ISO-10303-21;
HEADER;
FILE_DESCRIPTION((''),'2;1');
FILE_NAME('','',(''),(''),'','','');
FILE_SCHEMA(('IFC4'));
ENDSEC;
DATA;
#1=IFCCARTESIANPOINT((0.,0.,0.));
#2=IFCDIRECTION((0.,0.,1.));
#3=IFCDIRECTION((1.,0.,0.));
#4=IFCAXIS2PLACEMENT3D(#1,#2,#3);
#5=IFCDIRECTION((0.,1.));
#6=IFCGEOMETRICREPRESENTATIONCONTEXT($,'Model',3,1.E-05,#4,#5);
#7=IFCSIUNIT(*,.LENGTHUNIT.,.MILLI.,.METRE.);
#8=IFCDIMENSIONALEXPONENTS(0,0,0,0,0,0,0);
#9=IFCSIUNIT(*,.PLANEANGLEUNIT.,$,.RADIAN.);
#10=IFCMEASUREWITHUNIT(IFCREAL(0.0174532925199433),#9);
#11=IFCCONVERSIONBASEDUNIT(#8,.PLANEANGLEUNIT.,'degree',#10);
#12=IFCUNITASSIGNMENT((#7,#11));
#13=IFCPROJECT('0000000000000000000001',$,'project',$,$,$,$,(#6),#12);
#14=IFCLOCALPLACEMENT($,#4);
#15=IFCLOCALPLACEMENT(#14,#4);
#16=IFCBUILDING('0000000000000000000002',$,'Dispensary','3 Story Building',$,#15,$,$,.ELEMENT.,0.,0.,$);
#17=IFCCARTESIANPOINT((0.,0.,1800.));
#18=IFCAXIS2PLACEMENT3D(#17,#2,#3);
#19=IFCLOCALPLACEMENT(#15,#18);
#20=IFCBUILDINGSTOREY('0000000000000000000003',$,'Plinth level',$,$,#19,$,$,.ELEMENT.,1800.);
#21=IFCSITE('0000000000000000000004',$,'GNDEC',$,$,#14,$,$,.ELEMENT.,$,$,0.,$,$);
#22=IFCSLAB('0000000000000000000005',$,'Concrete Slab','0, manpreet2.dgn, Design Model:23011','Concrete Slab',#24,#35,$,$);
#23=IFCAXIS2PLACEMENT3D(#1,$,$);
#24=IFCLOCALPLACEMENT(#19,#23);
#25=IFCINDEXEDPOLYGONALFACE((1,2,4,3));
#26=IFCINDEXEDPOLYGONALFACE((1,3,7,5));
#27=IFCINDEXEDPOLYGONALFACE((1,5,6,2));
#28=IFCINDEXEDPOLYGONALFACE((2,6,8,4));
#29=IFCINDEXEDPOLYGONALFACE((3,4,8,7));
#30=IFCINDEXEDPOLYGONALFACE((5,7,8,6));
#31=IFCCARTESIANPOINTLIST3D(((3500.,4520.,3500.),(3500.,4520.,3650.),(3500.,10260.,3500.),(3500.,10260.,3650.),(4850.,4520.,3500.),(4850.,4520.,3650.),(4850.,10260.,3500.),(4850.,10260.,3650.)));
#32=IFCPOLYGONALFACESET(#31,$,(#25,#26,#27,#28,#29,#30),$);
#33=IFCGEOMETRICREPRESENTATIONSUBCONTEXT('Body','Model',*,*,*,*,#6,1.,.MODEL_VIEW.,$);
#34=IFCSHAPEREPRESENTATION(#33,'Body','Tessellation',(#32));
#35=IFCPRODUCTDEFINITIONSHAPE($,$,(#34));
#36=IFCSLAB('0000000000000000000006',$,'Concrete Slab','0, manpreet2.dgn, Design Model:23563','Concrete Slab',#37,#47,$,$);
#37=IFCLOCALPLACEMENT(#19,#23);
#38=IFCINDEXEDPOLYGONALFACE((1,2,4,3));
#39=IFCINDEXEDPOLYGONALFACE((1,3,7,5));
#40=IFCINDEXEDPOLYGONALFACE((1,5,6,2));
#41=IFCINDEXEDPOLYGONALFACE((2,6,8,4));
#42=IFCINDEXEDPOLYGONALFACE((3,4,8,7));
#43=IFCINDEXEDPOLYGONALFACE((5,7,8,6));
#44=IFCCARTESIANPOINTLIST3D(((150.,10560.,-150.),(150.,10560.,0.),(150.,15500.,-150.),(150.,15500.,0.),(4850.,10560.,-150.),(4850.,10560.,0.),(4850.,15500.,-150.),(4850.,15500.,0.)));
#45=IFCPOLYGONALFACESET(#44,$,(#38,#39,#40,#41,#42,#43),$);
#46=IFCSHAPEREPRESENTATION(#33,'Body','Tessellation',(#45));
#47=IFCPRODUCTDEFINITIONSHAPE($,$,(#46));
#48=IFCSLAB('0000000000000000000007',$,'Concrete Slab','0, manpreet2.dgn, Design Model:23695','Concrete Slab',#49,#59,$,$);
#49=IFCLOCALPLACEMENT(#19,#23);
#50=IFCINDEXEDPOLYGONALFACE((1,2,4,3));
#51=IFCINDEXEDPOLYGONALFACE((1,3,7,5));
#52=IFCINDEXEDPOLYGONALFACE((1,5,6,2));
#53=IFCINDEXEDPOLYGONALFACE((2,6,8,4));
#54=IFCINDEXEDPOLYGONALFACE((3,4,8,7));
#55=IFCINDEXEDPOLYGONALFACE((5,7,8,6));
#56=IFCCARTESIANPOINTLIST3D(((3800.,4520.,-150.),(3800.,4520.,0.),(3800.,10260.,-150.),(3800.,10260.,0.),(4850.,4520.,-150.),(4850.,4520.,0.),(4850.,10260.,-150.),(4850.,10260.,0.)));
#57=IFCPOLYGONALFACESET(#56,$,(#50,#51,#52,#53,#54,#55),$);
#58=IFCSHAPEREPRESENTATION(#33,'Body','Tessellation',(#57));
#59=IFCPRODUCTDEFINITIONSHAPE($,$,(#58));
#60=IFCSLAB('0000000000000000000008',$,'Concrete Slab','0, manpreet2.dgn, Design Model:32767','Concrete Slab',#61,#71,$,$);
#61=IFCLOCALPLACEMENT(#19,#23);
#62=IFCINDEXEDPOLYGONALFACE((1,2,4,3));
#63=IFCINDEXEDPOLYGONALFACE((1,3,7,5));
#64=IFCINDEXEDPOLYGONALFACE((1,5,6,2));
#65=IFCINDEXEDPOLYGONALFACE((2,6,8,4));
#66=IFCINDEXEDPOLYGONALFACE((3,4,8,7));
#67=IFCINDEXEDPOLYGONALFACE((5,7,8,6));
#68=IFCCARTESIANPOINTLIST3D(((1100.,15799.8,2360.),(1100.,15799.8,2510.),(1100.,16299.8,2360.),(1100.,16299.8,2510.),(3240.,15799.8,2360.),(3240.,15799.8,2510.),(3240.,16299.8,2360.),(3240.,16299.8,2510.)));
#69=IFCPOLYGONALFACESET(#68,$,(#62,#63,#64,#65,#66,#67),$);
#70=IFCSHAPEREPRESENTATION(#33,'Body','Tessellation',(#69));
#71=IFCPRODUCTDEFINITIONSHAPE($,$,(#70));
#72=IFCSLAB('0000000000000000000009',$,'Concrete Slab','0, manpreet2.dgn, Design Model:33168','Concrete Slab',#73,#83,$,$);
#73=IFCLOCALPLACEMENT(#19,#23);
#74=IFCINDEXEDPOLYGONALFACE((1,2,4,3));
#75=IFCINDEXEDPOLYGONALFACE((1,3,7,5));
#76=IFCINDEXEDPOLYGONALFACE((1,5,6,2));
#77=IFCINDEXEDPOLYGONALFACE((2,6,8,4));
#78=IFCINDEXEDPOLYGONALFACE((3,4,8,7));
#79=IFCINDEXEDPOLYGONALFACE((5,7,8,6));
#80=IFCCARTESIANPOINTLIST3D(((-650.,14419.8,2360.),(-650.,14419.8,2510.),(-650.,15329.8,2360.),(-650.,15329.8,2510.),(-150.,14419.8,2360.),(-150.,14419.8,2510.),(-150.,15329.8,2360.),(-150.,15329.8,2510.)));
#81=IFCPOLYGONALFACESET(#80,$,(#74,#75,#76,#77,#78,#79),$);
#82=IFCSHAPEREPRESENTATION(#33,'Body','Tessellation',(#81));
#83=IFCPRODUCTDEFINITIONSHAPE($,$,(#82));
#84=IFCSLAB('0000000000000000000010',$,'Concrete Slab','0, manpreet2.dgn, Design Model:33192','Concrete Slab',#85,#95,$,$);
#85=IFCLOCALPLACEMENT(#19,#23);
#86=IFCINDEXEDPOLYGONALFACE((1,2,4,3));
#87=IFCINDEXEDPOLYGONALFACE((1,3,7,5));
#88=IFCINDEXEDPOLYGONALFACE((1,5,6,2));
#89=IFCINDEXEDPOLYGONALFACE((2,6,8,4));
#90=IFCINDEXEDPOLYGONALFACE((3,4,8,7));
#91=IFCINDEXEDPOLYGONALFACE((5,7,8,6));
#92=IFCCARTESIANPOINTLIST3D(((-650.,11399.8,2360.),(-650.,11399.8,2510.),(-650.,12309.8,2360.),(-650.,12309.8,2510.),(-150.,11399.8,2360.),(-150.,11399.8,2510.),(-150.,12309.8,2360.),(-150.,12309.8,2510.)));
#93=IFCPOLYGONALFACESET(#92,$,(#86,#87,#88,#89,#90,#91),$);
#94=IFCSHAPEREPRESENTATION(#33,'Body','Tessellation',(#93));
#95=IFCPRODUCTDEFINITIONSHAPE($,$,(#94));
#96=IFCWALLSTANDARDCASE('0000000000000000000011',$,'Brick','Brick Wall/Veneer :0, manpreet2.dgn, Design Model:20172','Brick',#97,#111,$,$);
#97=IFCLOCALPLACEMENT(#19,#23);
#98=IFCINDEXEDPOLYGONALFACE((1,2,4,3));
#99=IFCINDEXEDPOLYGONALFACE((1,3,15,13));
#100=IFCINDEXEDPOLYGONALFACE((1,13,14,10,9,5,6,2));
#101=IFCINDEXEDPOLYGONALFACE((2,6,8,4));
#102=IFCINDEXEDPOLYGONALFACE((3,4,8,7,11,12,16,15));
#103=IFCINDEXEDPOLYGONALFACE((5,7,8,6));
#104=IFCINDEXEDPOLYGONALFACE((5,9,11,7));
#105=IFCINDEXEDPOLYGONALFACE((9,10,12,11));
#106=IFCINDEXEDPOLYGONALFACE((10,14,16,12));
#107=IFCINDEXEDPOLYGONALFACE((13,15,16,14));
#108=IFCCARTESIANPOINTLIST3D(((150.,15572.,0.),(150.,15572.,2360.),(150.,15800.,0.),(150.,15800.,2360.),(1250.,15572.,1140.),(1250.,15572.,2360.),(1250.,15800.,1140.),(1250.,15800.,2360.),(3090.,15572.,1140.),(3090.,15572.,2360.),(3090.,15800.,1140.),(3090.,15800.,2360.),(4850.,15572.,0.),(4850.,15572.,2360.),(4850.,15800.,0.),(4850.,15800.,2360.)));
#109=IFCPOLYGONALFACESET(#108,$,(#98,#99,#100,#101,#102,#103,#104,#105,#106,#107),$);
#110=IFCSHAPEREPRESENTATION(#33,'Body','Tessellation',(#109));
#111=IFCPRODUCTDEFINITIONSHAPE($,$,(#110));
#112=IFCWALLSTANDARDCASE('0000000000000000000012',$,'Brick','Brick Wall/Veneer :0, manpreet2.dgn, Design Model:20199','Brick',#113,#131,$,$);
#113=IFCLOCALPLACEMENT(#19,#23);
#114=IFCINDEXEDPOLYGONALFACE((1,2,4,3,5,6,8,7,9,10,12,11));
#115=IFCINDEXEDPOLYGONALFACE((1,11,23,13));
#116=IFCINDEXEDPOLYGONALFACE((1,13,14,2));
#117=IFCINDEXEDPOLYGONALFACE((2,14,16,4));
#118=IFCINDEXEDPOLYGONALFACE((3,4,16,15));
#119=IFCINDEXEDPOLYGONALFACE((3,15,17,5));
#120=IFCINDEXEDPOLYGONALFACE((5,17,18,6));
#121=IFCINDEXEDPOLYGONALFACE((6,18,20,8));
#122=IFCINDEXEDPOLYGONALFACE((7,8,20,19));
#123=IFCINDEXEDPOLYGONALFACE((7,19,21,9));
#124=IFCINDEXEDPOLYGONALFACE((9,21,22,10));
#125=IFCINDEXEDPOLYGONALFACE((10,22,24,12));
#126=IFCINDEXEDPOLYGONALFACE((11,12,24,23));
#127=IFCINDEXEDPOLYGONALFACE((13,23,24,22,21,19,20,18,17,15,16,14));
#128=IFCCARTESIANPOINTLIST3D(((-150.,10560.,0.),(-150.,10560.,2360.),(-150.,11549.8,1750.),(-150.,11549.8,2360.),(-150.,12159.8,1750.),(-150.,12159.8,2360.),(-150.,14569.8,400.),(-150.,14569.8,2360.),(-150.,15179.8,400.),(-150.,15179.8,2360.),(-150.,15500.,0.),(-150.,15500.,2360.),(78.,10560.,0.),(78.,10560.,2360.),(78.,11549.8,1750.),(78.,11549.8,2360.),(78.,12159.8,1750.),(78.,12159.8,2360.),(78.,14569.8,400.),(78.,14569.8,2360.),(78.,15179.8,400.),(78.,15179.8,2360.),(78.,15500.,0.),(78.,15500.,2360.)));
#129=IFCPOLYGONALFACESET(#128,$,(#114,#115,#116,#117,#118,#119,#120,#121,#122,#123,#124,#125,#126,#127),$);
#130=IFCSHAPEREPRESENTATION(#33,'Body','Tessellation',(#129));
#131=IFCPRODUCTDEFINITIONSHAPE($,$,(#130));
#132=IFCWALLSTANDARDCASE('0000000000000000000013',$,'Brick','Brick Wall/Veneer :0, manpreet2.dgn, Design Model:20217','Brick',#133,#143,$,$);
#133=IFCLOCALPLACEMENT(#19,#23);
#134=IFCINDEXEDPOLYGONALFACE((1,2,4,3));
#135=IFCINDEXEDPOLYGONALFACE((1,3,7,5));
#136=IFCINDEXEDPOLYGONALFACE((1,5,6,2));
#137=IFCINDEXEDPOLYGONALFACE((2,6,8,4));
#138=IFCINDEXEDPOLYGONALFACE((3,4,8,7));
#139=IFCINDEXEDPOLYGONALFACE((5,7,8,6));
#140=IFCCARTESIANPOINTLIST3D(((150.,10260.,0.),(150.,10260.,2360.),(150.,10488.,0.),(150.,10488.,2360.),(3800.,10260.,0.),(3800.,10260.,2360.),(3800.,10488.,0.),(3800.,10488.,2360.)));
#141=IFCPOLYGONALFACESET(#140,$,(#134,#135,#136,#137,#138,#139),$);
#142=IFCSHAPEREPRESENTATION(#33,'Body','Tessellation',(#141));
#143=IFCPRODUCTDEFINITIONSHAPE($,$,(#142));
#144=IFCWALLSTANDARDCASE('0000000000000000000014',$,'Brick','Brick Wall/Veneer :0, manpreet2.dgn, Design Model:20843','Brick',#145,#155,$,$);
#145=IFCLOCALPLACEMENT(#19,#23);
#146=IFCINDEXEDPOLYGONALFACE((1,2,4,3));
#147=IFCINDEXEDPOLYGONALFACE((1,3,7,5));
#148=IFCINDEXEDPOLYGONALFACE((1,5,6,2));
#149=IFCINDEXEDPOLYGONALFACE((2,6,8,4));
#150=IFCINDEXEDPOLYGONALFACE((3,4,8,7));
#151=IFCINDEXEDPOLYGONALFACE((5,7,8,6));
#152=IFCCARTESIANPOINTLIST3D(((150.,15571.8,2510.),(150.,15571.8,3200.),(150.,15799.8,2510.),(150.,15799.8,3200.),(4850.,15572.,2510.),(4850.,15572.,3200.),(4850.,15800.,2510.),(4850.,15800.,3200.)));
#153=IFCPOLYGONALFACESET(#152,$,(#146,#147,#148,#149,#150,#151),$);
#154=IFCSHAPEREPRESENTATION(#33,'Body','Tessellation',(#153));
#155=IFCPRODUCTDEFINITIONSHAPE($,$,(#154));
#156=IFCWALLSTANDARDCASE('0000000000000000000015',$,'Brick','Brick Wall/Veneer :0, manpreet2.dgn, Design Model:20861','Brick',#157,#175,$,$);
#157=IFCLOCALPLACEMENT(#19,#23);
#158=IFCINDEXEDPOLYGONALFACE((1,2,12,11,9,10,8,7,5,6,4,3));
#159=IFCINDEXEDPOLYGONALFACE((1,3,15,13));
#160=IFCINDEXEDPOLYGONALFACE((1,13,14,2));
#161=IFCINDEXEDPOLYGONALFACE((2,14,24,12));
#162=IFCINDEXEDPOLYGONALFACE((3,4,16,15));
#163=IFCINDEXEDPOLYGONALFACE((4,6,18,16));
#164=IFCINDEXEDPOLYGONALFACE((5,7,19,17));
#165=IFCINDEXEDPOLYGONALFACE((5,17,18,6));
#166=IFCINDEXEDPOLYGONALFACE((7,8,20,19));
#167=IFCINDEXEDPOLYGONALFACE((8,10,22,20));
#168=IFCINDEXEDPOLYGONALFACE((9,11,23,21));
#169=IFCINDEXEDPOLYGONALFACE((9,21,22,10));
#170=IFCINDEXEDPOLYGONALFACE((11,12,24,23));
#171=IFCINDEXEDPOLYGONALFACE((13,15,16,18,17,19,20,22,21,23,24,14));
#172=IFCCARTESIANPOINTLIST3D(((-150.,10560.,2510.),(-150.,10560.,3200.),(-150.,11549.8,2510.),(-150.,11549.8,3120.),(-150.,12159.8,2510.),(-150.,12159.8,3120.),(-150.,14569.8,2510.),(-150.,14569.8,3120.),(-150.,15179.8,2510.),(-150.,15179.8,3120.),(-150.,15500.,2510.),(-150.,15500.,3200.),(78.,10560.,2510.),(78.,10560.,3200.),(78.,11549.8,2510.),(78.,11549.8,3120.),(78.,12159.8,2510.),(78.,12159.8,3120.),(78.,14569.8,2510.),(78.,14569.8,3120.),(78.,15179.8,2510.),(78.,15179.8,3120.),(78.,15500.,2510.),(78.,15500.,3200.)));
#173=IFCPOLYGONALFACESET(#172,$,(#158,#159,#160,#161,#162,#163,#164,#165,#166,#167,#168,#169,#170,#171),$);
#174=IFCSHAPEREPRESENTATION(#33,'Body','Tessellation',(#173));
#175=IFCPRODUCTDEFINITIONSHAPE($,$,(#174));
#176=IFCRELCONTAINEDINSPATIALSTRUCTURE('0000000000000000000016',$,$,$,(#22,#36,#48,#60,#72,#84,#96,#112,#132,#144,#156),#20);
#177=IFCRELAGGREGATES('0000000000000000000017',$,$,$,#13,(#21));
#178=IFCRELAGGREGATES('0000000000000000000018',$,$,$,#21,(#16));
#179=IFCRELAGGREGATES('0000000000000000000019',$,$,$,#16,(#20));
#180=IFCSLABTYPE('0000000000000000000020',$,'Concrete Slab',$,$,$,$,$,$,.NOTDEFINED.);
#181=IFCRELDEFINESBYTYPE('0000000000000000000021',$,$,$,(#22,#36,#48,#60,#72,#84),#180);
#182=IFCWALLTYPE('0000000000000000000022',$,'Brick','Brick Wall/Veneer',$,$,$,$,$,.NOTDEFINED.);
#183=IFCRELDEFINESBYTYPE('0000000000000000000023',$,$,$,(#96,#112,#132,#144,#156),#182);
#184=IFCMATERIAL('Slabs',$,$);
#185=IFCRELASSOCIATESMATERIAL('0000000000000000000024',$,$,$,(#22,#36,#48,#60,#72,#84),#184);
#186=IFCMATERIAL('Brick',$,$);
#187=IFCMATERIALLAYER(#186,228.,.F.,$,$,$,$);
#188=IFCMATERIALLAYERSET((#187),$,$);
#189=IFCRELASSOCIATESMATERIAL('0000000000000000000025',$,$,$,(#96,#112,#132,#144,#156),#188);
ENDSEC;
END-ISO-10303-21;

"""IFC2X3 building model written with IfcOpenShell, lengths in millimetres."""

from ifc_helpers import new_model, entity, si_unit, converted_unit, direction, frame, frame_2d, origin_with_axes, place, context, subcontext, project, spatial, rectangle, extrude, material, layer, layer_set, layer_usage, type_object, element, save


model = new_model("IFC2X3")

# Units and contexts
model_context = context("Model", 3, precision=1e-05, world=origin_with_axes(), true_north=direction((0.0, 1.0)))
body_context = subcontext(model_context, "Body", "Model", "MODEL_VIEW", scale=1.0)
ifc_project = project(units=[si_unit("LENGTHUNIT", "METRE", prefix="MILLI"), converted_unit("PLANEANGLEUNIT", "degree", entity("IfcReal", 0.0174532925199433), si_unit("PLANEANGLEUNIT", "RADIAN"), dimensions=[0, 0, 0, 0, 0, 0, 0])], contexts=[model_context])

# Site, building, storey
site_placement = place(None, origin_with_axes())
site = spatial("IfcSite", under=ifc_project, at=site_placement, Name="GNDEC", CompositionType="ELEMENT", RefElevation=0.0)
building_placement = place(site_placement, origin_with_axes())
building = spatial("IfcBuilding", under=site, at=building_placement, Name="Dispensary", Description="3 Story Building", CompositionType="ELEMENT", ElevationOfRefHeight=0.0, ElevationOfTerrain=0.0)
storey_placement = place(building_placement, frame((0.0, 0.0, 1800.0), z_axis=(0.0, 0.0, 1.0), x_axis=(1.0, 0.0, 0.0)))
storey = spatial("IfcBuildingStorey", under=building, at=storey_placement, Name="Plinth level", CompositionType="ELEMENT", Elevation=1800.0)

# Slabs
ifc_material_1 = material(Name="Slabs")
slab_type = type_object("IfcSlabType", Name="Concrete Slab", PredefinedType="NOTDEFINED")
slab_1_placement = place(storey_placement, frame((3500.0, 10260.0, 3500.0), z_axis=(0.0, 0.0, 1.0), x_axis=(0.0, -1.0, 0.0)))
element("IfcSlab", 1, at=slab_1_placement, inside=storey, type_object=slab_type, material=ifc_material_1, Name="Concrete Slab", Description="0, manpreet2.dgn, Design Model:23011", ObjectType="Concrete Slab", context=body_context, shape_type="SweptSolid", body=[
    extrude(rectangle(XDim=5740.0, YDim=1350.0, at=frame_2d((2870.0, 675.0), x_axis=(1.0, 0.0))), origin_with_axes(), (0.0, 0.0, 1.0), 150.0),
])
slab_2_placement = place(storey_placement, frame((150.0, 15500.0, 0.0), z_axis=(0.0, 0.0, -1.0), x_axis=(1.0, 0.0, 0.0)))
element("IfcSlab", 2, at=slab_2_placement, inside=storey, type_object=slab_type, material=ifc_material_1, Name="Concrete Slab", Description="0, manpreet2.dgn, Design Model:23563", ObjectType="Concrete Slab", context=body_context, shape_type="SweptSolid", body=[
    extrude(rectangle(XDim=4700.0, YDim=4940.0, at=frame_2d((2350.0, 2470.0), x_axis=(1.0, 0.0))), origin_with_axes(), (0.0, 0.0, 1.0), 150.0),
])
slab_3_placement = place(storey_placement, frame((4850.0, 10260.0, 0.0), z_axis=(0.0, 0.0, -1.0), x_axis=(0.0, -1.0, 0.0)))
element("IfcSlab", 3, at=slab_3_placement, inside=storey, type_object=slab_type, material=ifc_material_1, Name="Concrete Slab", Description="0, manpreet2.dgn, Design Model:23695", ObjectType="Concrete Slab", context=body_context, shape_type="SweptSolid", body=[
    extrude(rectangle(XDim=5740.0, YDim=1050.0, at=frame_2d((2870.0, 525.0), x_axis=(1.0, 0.0))), origin_with_axes(), (0.0, 0.0, 1.0), 150.0),
])
slab_4_placement = place(storey_placement, frame((1250.0, 15799.8, 2510.0), z_axis=(0.0, 0.0, -1.0), x_axis=(-1.0, 0.0, 0.0)))
element("IfcSlab", 4, at=slab_4_placement, inside=storey, type_object=slab_type, material=ifc_material_1, Name="Concrete Slab", Description="0, manpreet2.dgn, Design Model:32767", ObjectType="Concrete Slab", context=body_context, shape_type="SweptSolid", body=[
    extrude(rectangle(XDim=500.0, YDim=2140.0, at=frame_2d((-920.0, 250.0), x_axis=(0.0, 1.0))), origin_with_axes(), (0.0, 0.0, 1.0), 150.0),
])
for number, where, z_axis, x_axis, name, description in (
    (5, (-150.0, 14419.8, 2510.0), (0.0, 0.0, -1.0), (-1.0, 0.0, 0.0), "Concrete Slab", "0, manpreet2.dgn, Design Model:33168"),
    (6, (-150.0, 11399.8, 2510.0), (0.0, 0.0, -1.0), (-1.0, 0.0, 0.0), "Concrete Slab", "0, manpreet2.dgn, Design Model:33192"),
):
    element("IfcSlab", number, at=place(storey_placement, frame(where, z_axis=z_axis, x_axis=x_axis)), inside=storey, type_object=slab_type, material=ifc_material_1, Name=name, Description=description, ObjectType="Concrete Slab", context=body_context, shape_type="SweptSolid", body=[
        extrude(rectangle(XDim=500.0, YDim=910.0, at=frame_2d((250.0, 455.0), x_axis=(1.0, 0.0))), origin_with_axes(), (0.0, 0.0, 1.0), 150.0),
    ])

# Wall, opening
ifc_material_2 = material(Name="Brick")
ifc_layer = layer(ifc_material_2, 228.0, ventilated=False)
ifc_layer_set = layer_set([ifc_layer])
ifc_layer_usage = layer_usage(ifc_layer_set, "AXIS2", "POSITIVE", 0.0)
wall_type = type_object("IfcWallType", Name="Brick", Description="Brick Wall/Veneer", PredefinedType="NOTDEFINED")
wall_1_placement = place(storey_placement, frame((150.0, 15800.0, 0.0), z_axis=(0.0, 0.0, 1.0), x_axis=(1.0, 0.0, 0.0)))
wall_1 = element("IfcWallStandardCase", 7, at=wall_1_placement, inside=storey, type_object=wall_type, material=ifc_layer_usage, Name="Brick", Description="Brick Wall/Veneer :0, manpreet2.dgn, Design Model:20172", ObjectType="Brick", context=body_context, shape_type="SweptSolid", body=[
    extrude(rectangle(XDim=4700.0, YDim=228.0, at=frame_2d((2350.0, -114.0), x_axis=(-1.0, 0.0))), origin_with_axes(), (0.0, 0.0, 1.0), 2360.0),
])
opening_1_placement = place(wall_1_placement, frame((1100.0, -228.0, 1140.0), z_axis=(0.0, 0.0, 1.0), x_axis=(1.0, 0.0, 0.0)))
element("IfcOpeningElement", 8, at=opening_1_placement, cuts=wall_1, ObjectType="Opening", context=body_context, shape_type="SweptSolid", body=[
    extrude(rectangle(XDim=1220.0, YDim=1840.0, at=frame_2d((-920.0, 610.0), x_axis=(0.0, -1.0))), frame((0.0, 0.0, 0.0), z_axis=(0.0, 1.0, 0.0), x_axis=(-1.0, 0.0, 0.0)), (0.0, 0.0, 1.0), 228.0),
])

# Wall, openings
wall_2_placement = place(storey_placement, frame((-150.0, 10560.0, 0.0), z_axis=(0.0, 0.0, 1.0), x_axis=(0.0, 1.0, 0.0)))
wall_2 = element("IfcWallStandardCase", 9, at=wall_2_placement, inside=storey, type_object=wall_type, material=ifc_layer_usage, Name="Brick", Description="Brick Wall/Veneer :0, manpreet2.dgn, Design Model:20199", ObjectType="Brick", context=body_context, shape_type="SweptSolid", body=[
    extrude(rectangle(XDim=4940.0, YDim=228.0, at=frame_2d((2470.0, -114.0), x_axis=(-1.0, 0.0))), origin_with_axes(), (0.0, 0.0, 1.0), 2360.0),
])
opening_2_placement = place(wall_2_placement, frame((4009.8, -228.0, 400.0), z_axis=(0.0, 0.0, 1.0), x_axis=(1.0, 0.0, 0.0)))
element("IfcOpeningElement", 10, at=opening_2_placement, cuts=wall_2, ObjectType="Opening", context=body_context, shape_type="SweptSolid", body=[
    extrude(rectangle(XDim=2720.0, YDim=610.0, at=frame_2d((-305.0, 1360.0), x_axis=(0.0, -1.0))), frame((0.0, 0.0, 0.0), z_axis=(0.0, 1.0, 0.0), x_axis=(-1.0, 0.0, 0.0)), (0.0, 0.0, 1.0), 228.0),
])
opening_3_placement = place(wall_2_placement, frame((989.8, -228.0, 1750.0), z_axis=(0.0, 0.0, 1.0), x_axis=(1.0, 0.0, 0.0)))
element("IfcOpeningElement", 11, at=opening_3_placement, cuts=wall_2, ObjectType="Opening", context=body_context, shape_type="SweptSolid", body=[
    extrude(rectangle(XDim=1370.0, YDim=610.0, at=frame_2d((-305.0, 685.0), x_axis=(0.0, -1.0))), frame((0.0, 0.0, 0.0), z_axis=(0.0, 1.0, 0.0), x_axis=(-1.0, 0.0, 0.0)), (0.0, 0.0, 1.0), 228.0),
])

# Walls
wall_3_placement = place(storey_placement, frame((3800.0, 10260.0, 0.0), z_axis=(0.0, 0.0, 1.0), x_axis=(-1.0, 0.0, 0.0)))
element("IfcWallStandardCase", 12, at=wall_3_placement, inside=storey, type_object=wall_type, material=ifc_layer_usage, Name="Brick", Description="Brick Wall/Veneer :0, manpreet2.dgn, Design Model:20217", ObjectType="Brick", context=body_context, shape_type="SweptSolid", body=[
    extrude(rectangle(XDim=3650.0, YDim=228.0, at=frame_2d((1825.0, -114.0), x_axis=(-1.0, 0.0))), origin_with_axes(), (0.0, 0.0, 1.0), 2360.0),
])
wall_4_placement = place(storey_placement, frame((150.0, 15799.8, 2510.0), z_axis=(0.0, 0.0, 1.0), x_axis=(1.0, 0.000049, 0.0)))
element("IfcWallStandardCase", 13, at=wall_4_placement, inside=storey, type_object=wall_type, material=ifc_layer_usage, Name="Brick", Description="Brick Wall/Veneer :0, manpreet2.dgn, Design Model:20843", ObjectType="Brick", context=body_context, shape_type="SweptSolid", body=[
    extrude(rectangle(XDim=4700.0, YDim=228.0, at=frame_2d((2350.0, -114.0), x_axis=(-1.0, 0.0))), origin_with_axes(), (0.0, 0.0, 1.0), 690.0),
])

# Wall, openings
wall_5_placement = place(storey_placement, frame((-150.0, 10560.0, 2510.0), z_axis=(0.0, 0.0, 1.0), x_axis=(0.0, 1.0, 0.0)))
wall_5 = element("IfcWallStandardCase", 14, at=wall_5_placement, inside=storey, type_object=wall_type, material=ifc_layer_usage, Name="Brick", Description="Brick Wall/Veneer :0, manpreet2.dgn, Design Model:20861", ObjectType="Brick", context=body_context, shape_type="SweptSolid", body=[
    extrude(rectangle(XDim=4940.0, YDim=228.0, at=frame_2d((2470.0, -114.0), x_axis=(-1.0, 0.0))), origin_with_axes(), (0.0, 0.0, 1.0), 690.0),
])
opening_4_placement = place(wall_5_placement, frame((4009.8, -228.0, -2110.0), z_axis=(0.0, 0.0, 1.0), x_axis=(1.0, 0.0, 0.0)))
element("IfcOpeningElement", 15, at=opening_4_placement, cuts=wall_5, ObjectType="Opening", context=body_context, shape_type="SweptSolid", body=[
    extrude(rectangle(XDim=2720.0, YDim=610.0, at=frame_2d((-305.0, 1360.0), x_axis=(0.0, -1.0))), frame((0.0, 0.0, 0.0), z_axis=(0.0, 1.0, 0.0), x_axis=(-1.0, 0.0, 0.0)), (0.0, 0.0, 1.0), 228.0),
])
opening_5_placement = place(wall_5_placement, frame((989.8, -228.0, -760.0), z_axis=(0.0, 0.0, 1.0), x_axis=(1.0, 0.0, 0.0)))
element("IfcOpeningElement", 16, at=opening_5_placement, cuts=wall_5, ObjectType="Opening", context=body_context, shape_type="SweptSolid", body=[
    extrude(rectangle(XDim=1370.0, YDim=610.0, at=frame_2d((-305.0, 685.0), x_axis=(0.0, -1.0))), frame((0.0, 0.0, 0.0), z_axis=(0.0, 1.0, 0.0), x_axis=(-1.0, 0.0, 0.0)), (0.0, 0.0, 1.0), 228.0),
])

save(model, "model.ifc")
